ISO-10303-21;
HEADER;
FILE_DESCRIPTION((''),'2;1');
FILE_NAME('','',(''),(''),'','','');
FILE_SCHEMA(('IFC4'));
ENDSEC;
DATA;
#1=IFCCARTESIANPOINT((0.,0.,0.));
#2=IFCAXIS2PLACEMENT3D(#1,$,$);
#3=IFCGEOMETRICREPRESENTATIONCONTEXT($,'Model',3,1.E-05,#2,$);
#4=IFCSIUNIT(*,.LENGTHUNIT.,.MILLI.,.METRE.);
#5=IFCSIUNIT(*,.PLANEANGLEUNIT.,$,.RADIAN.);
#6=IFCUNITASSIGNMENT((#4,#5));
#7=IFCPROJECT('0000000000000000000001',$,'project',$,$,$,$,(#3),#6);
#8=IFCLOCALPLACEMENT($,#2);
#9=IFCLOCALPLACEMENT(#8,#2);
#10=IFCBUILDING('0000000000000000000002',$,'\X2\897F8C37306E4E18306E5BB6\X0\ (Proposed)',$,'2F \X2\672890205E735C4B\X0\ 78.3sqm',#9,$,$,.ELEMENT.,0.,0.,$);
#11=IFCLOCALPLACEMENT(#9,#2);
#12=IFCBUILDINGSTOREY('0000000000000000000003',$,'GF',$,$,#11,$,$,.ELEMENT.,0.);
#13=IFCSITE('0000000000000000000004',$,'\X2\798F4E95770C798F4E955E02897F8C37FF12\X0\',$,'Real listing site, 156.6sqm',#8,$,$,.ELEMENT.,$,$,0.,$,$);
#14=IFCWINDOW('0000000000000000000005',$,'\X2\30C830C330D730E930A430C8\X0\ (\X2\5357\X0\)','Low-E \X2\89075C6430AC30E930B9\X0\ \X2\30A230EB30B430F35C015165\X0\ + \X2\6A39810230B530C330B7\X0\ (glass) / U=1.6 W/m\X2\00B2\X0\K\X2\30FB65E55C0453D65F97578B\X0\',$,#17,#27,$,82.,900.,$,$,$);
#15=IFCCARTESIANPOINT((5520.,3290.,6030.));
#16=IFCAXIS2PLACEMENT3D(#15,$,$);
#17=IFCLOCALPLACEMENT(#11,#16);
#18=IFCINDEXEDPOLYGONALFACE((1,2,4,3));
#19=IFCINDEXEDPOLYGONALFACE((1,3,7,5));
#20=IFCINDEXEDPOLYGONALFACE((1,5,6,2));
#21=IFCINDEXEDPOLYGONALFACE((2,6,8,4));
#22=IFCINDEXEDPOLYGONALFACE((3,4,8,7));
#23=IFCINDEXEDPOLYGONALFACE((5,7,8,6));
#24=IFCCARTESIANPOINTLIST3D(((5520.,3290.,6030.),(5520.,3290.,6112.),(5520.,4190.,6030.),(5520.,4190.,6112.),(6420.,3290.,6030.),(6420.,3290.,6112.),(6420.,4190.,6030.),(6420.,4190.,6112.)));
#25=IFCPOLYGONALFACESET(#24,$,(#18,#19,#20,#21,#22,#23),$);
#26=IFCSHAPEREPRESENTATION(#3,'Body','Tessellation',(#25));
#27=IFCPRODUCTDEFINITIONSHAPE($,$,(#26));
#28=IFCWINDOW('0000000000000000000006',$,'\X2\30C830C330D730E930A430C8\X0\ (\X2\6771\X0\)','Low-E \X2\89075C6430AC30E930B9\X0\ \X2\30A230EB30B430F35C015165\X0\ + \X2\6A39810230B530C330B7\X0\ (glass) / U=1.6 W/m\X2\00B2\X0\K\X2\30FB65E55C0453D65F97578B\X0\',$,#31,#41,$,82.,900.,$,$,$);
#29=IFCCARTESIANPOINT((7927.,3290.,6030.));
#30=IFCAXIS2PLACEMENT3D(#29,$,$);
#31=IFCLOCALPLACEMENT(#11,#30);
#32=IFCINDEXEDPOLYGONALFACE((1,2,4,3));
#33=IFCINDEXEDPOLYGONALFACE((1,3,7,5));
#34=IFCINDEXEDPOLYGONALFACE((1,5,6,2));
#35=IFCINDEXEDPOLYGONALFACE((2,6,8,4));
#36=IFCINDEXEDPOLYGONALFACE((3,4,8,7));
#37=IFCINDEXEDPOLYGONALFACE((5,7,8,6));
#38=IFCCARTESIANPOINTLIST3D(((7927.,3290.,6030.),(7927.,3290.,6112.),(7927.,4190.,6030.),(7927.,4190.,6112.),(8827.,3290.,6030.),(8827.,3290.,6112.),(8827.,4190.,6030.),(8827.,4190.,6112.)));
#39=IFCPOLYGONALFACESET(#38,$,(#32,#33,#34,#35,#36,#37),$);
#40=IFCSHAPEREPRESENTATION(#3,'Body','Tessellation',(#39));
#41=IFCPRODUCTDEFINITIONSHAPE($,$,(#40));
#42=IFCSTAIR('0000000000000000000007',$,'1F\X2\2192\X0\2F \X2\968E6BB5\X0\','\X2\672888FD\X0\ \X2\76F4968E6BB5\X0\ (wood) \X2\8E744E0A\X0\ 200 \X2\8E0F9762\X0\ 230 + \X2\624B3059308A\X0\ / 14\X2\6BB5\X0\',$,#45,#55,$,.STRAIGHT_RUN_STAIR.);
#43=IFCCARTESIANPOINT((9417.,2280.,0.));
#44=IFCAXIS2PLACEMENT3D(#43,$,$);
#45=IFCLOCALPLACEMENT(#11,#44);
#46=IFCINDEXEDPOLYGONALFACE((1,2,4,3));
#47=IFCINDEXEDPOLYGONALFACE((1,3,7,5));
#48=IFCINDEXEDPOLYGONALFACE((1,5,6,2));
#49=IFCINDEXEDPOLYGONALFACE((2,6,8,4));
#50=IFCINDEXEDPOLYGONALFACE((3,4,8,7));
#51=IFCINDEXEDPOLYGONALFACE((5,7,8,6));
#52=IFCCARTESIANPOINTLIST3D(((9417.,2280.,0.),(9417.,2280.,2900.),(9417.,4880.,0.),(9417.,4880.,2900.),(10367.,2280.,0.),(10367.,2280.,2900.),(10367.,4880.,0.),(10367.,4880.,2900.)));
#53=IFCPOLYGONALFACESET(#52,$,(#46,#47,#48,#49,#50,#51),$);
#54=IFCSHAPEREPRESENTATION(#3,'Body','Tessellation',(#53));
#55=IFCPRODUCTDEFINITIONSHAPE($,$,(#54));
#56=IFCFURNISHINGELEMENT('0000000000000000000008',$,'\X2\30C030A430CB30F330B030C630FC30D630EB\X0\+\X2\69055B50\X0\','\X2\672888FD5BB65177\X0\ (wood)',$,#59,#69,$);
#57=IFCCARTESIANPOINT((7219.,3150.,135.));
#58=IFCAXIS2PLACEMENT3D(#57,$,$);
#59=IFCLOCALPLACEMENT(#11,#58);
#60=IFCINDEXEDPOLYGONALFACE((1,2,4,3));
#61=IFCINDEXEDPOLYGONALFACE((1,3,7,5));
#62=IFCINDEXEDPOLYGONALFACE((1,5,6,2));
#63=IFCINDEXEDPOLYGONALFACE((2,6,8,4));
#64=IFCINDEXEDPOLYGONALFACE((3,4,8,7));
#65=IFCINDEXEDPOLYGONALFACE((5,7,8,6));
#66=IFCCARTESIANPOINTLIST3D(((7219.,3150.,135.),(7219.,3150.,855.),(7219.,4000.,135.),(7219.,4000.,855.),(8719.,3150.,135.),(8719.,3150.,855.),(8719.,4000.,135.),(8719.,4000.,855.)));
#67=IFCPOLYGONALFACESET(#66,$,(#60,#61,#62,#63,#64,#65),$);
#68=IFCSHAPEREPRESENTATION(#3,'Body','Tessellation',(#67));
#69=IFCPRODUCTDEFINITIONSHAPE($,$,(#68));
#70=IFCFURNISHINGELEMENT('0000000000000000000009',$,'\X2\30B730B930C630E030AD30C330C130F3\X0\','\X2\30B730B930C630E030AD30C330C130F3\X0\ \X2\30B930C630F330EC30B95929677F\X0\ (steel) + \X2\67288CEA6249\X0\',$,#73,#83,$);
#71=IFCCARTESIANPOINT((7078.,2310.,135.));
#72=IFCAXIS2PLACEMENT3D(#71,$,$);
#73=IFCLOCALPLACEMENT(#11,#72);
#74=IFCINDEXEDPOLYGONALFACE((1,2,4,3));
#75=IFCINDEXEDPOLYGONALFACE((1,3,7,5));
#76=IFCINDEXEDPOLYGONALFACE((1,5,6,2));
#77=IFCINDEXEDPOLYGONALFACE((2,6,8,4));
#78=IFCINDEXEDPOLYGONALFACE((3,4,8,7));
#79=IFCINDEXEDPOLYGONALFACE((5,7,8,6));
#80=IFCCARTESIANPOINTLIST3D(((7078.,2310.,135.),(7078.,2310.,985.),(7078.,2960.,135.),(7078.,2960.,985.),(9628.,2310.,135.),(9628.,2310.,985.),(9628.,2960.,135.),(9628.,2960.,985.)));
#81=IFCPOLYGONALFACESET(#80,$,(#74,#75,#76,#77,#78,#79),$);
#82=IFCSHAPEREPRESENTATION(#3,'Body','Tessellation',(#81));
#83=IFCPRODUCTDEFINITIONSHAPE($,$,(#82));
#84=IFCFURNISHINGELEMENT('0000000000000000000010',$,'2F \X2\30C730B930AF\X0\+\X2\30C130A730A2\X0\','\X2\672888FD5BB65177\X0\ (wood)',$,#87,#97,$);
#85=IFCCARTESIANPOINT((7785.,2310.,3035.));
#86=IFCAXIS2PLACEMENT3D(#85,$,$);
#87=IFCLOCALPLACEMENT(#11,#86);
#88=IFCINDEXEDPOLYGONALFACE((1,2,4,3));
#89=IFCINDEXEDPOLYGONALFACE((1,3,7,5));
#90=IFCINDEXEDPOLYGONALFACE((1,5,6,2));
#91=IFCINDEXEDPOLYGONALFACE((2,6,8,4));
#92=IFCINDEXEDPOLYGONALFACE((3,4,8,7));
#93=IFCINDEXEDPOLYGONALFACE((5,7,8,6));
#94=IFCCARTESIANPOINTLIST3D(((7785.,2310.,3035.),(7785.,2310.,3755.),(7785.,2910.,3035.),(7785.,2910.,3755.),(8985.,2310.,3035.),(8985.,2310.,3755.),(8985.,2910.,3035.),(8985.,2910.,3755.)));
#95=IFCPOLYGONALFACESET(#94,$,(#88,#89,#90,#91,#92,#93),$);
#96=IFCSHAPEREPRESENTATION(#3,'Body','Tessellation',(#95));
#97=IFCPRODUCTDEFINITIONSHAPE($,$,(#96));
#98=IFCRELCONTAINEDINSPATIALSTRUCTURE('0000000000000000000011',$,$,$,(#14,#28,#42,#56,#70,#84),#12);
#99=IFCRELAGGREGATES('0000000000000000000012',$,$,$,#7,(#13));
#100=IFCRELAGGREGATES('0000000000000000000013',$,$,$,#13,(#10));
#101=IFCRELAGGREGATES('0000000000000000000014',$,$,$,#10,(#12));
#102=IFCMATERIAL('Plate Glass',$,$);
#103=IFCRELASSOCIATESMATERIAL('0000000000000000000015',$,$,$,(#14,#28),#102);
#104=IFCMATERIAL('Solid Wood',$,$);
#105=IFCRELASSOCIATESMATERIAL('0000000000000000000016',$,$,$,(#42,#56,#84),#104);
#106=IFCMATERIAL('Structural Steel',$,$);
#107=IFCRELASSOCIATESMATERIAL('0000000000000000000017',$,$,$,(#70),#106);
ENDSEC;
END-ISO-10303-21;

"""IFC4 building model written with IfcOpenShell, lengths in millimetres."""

from ifc_helpers import new_model, si_unit, frame, frame_2d, origin, place, context, project, spatial, rectangle, extrude, material, element, save


model = new_model("IFC4")

# Units and contexts
model_context = context("Model", 3, precision=1e-05, world=origin())
ifc_project = project(units=[si_unit("LENGTHUNIT", "METRE", prefix="MILLI"), si_unit("PLANEANGLEUNIT", "RADIAN")], contexts=[model_context])

# Site, building, storey
site_placement = place(None, origin())
site = spatial("IfcSite", under=ifc_project, at=site_placement, Name="福井県福井市西谷２", ObjectType="Real listing site, 156.6sqm", CompositionType="ELEMENT", RefElevation=0.0)
building_placement = place(site_placement, origin())
building = spatial("IfcBuilding", under=site, at=building_placement, Name="西谷の丘の家 (Proposed)", ObjectType="2F 木造平屋 78.3sqm", CompositionType="ELEMENT", ElevationOfRefHeight=0.0, ElevationOfTerrain=0.0)
storey_placement = place(building_placement, origin())
storey = spatial("IfcBuildingStorey", under=building, at=storey_placement, Name="GF", CompositionType="ELEMENT", Elevation=0.0)

# Shared definitions
ifc_material_1 = material(Name="Solid Wood")

# Shared definitions
ifc_material_2 = material(Name="Plate Glass")

# Windows
window_1_placement = place(storey_placement, frame((5520.0, 3290.0, 6030.0)))
element("IfcWindow", 1, at=window_1_placement, inside=storey, material=ifc_material_2, Name="トップライト (南)", Description="Low-E 複層ガラス アルゴン封入 + 樹脂サッシ (glass) / U=1.6 W/m²K・日射取得型", OverallHeight=82.0, OverallWidth=900.0, context=model_context, shape_type="SweptSolid", body=[
    extrude(rectangle(XDim=900.0, YDim=900.0, at=frame_2d((450.0, 450.0))), frame((5520.0, 3290.0, 6030.0)), (0.0, 0.0, 1.0), 82.0),
])
window_2_placement = place(storey_placement, frame((7927.0, 3290.0, 6030.0)))
element("IfcWindow", 2, at=window_2_placement, inside=storey, material=ifc_material_2, Name="トップライト (東)", Description="Low-E 複層ガラス アルゴン封入 + 樹脂サッシ (glass) / U=1.6 W/m²K・日射取得型", OverallHeight=82.0, OverallWidth=900.0, context=model_context, shape_type="SweptSolid", body=[
    extrude(rectangle(XDim=900.0, YDim=900.0, at=frame_2d((450.0, 450.0))), frame((7927.0, 3290.0, 6030.0)), (0.0, 0.0, 1.0), 82.0),
])

# Stair
stair_placement = place(storey_placement, frame((9417.0, 2280.0, 0.0)))
element("IfcStair", 3, at=stair_placement, inside=storey, material=ifc_material_1, Name="1F→2F 階段", Description="木製 直階段 (wood) 蹴上 200 踏面 230 + 手すり / 14段", PredefinedType="STRAIGHT_RUN_STAIR", context=model_context, shape_type="SweptSolid", body=[
    extrude(rectangle(XDim=950.0, YDim=2600.0, at=frame_2d((475.0, 1300.0))), frame((9417.0, 2280.0, 0.0)), (0.0, 0.0, 1.0), 2900.0),
])

# Furnishing elements
furnishing_1_placement = place(storey_placement, frame((7219.0, 3150.0, 135.0)))
element("IfcFurnishingElement", 4, at=furnishing_1_placement, inside=storey, material=ifc_material_1, Name="ダイニングテーブル+椅子", Description="木製家具 (wood)", context=model_context, shape_type="SweptSolid", body=[
    extrude(rectangle(XDim=1500.0, YDim=850.0, at=frame_2d((750.0, 425.0))), frame((7219.0, 3150.0, 135.0)), (0.0, 0.0, 1.0), 720.0),
])
ifc_material_3 = material(Name="Structural Steel")
furnishing_2_placement = place(storey_placement, frame((7078.0, 2310.0, 135.0)))
element("IfcFurnishingElement", 5, at=furnishing_2_placement, inside=storey, material=ifc_material_3, Name="システムキッチン", Description="システムキッチン ステンレス天板 (steel) + 木質扉", context=model_context, shape_type="SweptSolid", body=[
    extrude(rectangle(XDim=2550.0, YDim=650.0, at=frame_2d((1275.0, 325.0))), frame((7078.0, 2310.0, 135.0)), (0.0, 0.0, 1.0), 850.0),
])
furnishing_3_placement = place(storey_placement, frame((7785.0, 2310.0, 3035.0)))
element("IfcFurnishingElement", 6, at=furnishing_3_placement, inside=storey, material=ifc_material_1, Name="2F デスク+チェア", Description="木製家具 (wood)", context=model_context, shape_type="SweptSolid", body=[
    extrude(rectangle(XDim=1200.0, YDim=600.0, at=frame_2d((600.0, 300.0))), frame((7785.0, 2310.0, 3035.0)), (0.0, 0.0, 1.0), 720.0),
])

save(model, "model.ifc")
